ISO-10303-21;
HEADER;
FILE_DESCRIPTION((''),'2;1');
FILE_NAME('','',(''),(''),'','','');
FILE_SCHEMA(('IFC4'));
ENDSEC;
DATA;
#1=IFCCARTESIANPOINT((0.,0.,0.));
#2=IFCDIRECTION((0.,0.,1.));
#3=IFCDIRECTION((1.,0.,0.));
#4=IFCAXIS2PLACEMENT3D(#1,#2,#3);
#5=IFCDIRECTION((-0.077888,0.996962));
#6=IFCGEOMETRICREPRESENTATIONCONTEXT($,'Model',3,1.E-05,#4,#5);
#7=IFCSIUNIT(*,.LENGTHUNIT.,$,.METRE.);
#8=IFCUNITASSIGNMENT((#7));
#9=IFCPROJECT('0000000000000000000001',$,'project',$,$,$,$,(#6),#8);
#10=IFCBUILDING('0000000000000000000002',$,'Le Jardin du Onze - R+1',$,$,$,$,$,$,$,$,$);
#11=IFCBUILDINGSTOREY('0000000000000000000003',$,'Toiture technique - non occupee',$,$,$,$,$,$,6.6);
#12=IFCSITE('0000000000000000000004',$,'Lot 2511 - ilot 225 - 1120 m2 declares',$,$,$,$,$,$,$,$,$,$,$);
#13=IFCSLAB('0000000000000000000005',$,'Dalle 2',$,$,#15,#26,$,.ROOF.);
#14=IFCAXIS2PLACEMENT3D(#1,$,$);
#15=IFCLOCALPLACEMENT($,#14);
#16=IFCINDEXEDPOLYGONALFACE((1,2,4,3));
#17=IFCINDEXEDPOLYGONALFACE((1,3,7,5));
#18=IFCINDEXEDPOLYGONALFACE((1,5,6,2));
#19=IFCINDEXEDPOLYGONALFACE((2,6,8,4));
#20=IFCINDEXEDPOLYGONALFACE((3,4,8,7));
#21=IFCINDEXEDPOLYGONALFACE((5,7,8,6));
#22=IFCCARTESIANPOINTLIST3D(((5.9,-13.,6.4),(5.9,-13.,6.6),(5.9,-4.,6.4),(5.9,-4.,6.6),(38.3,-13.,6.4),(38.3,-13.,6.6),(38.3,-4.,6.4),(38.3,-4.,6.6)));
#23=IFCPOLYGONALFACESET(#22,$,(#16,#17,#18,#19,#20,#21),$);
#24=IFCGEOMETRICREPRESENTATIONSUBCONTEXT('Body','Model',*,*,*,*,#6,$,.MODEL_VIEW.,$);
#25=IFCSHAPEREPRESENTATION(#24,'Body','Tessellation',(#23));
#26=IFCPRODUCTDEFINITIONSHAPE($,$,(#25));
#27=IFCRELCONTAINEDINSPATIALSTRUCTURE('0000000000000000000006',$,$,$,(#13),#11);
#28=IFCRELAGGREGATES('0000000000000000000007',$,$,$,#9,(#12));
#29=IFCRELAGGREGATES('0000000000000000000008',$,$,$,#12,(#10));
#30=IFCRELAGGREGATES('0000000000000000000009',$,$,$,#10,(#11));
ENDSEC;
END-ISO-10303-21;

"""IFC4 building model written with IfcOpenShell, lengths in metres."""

from ifc_helpers import new_model, si_unit, direction, frame, origin_with_axes, place, context, subcontext, project, spatial, polyline, outline, extrude, element, save


model = new_model("IFC4")

# Units and contexts
model_context = context("Model", 3, precision=1e-05, world=origin_with_axes(), true_north=direction((-0.077888, 0.996962)))
body_context = subcontext(model_context, "Body", "Model", "MODEL_VIEW")
ifc_project = project(units=[si_unit("LENGTHUNIT", "METRE")], contexts=[model_context])

# Site, building, storey
site = spatial("IfcSite", under=ifc_project, Name="Lot 2511 - ilot 225 - 1120 m2 declares")
building = spatial("IfcBuilding", under=site, Name="Le Jardin du Onze - R+1")
storey = spatial("IfcBuildingStorey", under=building, Name="Toiture technique - non occupee", Elevation=6.6)

# Slab
slab_placement = place(None, origin_with_axes())
element("IfcSlab", 1, at=slab_placement, inside=storey, Name="Dalle 2", PredefinedType="ROOF", context=body_context, shape_type="SweptSolid", body=[
    extrude(outline(polyline([(38.3, -13.0), (38.3, -4.0), (5.9, -4.0), (5.9, -13.0), (38.3, -13.0)])), frame((0.0, 0.0, 6.4)), (0.0, 0.0, 1.0), 0.2),
])

save(model, "model.ifc")
